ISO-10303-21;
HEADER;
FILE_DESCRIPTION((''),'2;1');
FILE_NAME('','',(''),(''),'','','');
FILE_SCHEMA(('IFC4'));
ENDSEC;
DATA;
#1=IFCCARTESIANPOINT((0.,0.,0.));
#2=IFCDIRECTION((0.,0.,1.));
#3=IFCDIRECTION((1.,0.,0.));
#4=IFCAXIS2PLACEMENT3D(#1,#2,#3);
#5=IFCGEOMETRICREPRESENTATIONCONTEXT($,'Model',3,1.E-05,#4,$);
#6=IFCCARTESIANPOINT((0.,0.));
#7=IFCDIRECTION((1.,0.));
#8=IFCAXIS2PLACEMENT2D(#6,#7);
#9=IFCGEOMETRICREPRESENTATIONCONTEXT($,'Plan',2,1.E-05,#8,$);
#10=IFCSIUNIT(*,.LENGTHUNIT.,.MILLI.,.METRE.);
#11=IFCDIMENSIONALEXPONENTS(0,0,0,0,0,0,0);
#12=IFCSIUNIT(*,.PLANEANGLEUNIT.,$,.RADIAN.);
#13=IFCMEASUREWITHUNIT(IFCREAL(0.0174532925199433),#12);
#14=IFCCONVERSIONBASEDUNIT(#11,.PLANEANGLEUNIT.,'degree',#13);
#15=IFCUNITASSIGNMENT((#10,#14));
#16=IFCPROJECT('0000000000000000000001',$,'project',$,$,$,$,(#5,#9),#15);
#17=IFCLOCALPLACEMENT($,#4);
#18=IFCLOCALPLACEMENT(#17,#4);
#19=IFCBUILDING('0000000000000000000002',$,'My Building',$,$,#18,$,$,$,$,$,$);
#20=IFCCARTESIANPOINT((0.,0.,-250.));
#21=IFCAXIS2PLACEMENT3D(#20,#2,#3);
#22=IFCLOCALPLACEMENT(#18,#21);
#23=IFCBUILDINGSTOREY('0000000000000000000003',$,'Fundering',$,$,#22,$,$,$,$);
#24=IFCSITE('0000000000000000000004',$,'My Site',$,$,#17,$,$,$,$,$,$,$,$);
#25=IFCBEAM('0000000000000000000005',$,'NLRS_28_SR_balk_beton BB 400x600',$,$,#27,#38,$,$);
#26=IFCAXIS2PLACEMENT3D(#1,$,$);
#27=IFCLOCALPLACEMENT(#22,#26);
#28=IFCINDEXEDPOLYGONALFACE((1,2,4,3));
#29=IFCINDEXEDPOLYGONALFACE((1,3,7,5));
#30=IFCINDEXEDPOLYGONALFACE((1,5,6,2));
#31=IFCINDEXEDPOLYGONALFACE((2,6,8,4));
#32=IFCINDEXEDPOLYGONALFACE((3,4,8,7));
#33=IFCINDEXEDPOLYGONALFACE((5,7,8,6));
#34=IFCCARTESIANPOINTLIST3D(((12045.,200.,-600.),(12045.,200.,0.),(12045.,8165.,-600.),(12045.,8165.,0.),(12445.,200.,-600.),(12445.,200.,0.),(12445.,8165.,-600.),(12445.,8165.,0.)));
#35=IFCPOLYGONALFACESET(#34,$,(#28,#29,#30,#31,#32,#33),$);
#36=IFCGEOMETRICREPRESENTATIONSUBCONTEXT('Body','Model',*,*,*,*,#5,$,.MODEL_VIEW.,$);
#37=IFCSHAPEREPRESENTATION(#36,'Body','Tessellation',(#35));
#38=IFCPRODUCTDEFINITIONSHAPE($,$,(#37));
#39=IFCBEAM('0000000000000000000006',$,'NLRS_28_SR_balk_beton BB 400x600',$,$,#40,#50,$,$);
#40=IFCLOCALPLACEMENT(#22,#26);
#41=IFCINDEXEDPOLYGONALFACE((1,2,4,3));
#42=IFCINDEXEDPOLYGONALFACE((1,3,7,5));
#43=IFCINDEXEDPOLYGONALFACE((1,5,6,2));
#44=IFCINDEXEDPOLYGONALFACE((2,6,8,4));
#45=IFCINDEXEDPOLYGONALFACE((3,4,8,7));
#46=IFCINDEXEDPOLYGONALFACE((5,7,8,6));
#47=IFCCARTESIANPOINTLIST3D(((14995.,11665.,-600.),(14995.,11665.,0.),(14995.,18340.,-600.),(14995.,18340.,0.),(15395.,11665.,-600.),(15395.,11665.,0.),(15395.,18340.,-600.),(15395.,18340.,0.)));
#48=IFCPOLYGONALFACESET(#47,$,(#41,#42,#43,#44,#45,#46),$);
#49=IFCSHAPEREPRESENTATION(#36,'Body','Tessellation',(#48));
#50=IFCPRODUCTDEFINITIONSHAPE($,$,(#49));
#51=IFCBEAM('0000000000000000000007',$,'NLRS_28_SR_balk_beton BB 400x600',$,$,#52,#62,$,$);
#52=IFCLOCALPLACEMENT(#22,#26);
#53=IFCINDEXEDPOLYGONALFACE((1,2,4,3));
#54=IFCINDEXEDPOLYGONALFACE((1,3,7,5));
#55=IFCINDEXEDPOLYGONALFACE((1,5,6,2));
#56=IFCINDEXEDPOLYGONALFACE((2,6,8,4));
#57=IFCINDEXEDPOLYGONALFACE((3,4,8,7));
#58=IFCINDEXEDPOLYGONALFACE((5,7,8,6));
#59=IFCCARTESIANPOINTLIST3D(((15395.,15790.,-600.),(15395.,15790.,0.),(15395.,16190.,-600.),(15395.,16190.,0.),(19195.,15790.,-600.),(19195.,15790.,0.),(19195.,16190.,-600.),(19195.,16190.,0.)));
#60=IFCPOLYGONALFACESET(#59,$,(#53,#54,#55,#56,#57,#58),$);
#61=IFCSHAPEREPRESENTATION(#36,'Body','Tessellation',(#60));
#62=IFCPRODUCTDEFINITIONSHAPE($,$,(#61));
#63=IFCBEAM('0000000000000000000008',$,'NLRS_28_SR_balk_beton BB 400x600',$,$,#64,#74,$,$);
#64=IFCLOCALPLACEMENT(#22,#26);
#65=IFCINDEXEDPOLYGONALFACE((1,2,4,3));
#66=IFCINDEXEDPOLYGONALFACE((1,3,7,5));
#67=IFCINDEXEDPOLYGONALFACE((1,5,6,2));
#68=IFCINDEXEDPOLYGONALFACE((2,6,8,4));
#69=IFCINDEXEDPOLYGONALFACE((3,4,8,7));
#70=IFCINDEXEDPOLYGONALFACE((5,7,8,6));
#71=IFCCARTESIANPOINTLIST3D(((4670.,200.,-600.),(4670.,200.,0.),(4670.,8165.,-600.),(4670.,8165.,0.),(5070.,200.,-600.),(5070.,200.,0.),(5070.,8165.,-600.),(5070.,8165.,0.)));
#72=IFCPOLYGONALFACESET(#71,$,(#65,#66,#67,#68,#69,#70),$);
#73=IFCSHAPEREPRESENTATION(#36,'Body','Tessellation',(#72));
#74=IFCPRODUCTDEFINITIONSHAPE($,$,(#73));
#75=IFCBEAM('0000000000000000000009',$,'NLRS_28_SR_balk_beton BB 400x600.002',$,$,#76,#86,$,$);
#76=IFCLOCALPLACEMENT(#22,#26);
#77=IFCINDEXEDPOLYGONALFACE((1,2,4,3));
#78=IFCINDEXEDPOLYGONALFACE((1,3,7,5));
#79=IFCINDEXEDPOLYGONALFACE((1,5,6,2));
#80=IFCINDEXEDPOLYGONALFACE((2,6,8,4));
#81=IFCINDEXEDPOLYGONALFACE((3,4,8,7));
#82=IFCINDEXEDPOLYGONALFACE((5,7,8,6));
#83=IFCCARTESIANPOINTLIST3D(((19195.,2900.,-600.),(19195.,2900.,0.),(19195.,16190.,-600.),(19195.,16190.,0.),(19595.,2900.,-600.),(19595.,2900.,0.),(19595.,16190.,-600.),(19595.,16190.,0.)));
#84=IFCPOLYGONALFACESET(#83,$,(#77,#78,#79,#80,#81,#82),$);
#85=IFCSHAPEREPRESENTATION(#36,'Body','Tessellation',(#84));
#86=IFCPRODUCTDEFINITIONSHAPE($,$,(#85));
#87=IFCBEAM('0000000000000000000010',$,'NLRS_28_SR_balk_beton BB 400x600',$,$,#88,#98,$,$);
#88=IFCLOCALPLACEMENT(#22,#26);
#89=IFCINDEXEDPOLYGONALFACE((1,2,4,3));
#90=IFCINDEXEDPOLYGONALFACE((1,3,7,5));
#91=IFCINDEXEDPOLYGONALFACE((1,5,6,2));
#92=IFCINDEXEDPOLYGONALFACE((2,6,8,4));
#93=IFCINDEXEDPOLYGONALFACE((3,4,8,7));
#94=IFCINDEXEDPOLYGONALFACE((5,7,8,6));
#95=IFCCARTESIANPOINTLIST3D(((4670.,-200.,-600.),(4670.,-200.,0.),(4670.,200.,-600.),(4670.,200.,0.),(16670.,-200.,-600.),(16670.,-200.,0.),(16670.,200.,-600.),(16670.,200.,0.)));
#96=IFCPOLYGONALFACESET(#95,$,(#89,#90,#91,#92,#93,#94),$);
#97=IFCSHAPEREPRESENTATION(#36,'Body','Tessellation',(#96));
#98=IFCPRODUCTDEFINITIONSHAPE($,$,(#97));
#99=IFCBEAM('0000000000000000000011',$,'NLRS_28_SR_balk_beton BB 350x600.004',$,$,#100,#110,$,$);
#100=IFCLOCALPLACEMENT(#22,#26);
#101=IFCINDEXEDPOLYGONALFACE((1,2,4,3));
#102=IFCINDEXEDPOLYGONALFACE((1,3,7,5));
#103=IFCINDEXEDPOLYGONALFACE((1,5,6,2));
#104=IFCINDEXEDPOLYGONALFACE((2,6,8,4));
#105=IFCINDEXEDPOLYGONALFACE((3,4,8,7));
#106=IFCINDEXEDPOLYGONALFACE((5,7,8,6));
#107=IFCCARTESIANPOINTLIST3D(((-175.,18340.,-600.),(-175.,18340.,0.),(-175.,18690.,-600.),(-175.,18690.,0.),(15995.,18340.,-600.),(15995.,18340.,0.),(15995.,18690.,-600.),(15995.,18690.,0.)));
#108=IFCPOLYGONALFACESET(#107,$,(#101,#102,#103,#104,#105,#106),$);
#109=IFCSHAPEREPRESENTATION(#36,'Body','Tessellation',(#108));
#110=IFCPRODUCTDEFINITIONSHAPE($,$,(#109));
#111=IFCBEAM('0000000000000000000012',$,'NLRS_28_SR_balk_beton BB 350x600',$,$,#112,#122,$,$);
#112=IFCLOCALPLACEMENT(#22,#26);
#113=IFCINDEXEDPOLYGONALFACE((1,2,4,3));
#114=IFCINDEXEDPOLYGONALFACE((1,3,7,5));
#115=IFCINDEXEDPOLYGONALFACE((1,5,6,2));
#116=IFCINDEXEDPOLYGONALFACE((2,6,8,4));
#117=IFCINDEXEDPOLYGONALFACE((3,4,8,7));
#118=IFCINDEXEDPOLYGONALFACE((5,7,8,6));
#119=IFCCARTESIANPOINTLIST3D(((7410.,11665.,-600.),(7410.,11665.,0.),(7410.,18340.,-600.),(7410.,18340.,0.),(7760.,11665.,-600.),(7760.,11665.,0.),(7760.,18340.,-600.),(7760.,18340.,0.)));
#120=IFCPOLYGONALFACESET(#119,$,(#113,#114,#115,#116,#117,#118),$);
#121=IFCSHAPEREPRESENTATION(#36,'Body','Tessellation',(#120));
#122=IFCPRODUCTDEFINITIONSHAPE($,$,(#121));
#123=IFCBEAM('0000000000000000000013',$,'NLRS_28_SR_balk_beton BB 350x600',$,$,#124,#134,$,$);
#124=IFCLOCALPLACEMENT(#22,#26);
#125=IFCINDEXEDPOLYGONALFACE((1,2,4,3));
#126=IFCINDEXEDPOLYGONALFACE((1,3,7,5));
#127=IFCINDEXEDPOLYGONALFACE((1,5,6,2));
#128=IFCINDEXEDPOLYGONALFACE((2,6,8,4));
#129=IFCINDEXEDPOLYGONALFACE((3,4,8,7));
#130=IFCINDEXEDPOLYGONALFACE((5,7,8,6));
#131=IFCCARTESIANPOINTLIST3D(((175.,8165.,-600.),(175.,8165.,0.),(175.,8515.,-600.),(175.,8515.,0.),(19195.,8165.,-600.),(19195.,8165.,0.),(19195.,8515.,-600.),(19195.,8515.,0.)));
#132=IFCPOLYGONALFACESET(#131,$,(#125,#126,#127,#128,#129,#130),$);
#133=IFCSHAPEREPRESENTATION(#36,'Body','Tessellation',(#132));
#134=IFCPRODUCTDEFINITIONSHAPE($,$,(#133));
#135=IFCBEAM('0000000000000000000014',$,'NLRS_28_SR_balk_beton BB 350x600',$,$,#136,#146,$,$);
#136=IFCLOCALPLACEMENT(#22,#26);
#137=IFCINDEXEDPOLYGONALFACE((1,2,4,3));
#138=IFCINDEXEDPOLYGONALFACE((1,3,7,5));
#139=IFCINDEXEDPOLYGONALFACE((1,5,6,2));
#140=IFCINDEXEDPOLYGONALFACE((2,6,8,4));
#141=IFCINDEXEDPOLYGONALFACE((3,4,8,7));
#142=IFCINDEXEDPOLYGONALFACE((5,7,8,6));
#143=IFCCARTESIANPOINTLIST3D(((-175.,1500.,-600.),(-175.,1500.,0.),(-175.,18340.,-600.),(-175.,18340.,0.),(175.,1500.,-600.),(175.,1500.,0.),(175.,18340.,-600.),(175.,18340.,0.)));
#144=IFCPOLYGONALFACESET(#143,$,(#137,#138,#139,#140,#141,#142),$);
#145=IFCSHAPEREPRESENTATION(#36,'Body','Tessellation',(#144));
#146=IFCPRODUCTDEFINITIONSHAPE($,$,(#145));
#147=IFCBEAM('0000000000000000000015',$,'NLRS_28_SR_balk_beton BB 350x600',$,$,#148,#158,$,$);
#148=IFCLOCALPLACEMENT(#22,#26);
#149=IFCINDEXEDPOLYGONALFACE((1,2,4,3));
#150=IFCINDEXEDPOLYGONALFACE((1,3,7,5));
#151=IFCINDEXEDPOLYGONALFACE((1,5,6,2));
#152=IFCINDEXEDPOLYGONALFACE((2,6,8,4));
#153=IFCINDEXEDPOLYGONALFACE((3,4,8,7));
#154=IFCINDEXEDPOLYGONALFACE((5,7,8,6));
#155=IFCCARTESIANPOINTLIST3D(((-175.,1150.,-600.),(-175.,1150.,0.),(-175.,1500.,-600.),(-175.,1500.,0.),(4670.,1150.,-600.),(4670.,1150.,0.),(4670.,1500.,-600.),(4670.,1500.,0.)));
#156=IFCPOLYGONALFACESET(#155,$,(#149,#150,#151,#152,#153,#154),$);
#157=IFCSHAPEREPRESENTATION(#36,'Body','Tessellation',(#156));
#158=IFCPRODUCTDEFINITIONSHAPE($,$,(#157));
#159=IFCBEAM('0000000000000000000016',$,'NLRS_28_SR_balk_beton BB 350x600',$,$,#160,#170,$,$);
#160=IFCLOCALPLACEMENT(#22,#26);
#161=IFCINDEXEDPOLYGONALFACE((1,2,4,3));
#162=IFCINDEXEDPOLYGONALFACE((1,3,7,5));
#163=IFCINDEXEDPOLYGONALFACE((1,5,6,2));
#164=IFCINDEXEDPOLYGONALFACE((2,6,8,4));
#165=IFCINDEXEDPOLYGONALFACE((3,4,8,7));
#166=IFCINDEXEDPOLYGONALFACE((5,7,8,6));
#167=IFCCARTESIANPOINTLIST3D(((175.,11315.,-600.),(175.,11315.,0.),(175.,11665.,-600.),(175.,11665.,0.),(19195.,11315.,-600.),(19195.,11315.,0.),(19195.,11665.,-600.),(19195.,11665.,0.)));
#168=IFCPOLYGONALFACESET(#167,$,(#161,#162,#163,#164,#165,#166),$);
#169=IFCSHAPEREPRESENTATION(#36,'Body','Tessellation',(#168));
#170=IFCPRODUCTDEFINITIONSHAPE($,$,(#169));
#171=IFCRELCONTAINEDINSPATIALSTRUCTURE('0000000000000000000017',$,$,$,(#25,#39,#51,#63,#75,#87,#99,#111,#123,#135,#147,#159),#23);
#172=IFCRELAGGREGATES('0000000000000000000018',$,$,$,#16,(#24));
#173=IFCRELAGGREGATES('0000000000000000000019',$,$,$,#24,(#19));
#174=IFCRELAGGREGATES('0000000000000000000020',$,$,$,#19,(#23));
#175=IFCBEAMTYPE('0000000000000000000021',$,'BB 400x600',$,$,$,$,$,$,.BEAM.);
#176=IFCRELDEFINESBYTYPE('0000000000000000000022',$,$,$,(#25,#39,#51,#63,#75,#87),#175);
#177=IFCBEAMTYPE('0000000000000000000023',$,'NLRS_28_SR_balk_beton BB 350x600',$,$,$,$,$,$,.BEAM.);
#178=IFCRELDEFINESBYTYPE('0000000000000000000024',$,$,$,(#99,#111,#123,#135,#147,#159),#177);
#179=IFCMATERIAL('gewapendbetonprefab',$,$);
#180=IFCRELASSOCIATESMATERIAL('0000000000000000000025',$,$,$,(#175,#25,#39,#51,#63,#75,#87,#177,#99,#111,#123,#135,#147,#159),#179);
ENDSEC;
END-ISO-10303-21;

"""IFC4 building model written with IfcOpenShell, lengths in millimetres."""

from ifc_helpers import new_model, entity, si_unit, converted_unit, frame, origin_with_axes, origin_2d_with_axis, place, context, subcontext, project, spatial, rectangle, extrude, material, material_profile, profile_set, profile_usage, type_object, element, save


model = new_model("IFC4")

# Units and contexts
model_context = context("Model", 3, precision=1e-05, world=origin_with_axes())
plan_context = context("Plan", 2, precision=1e-05, world=origin_2d_with_axis())
body_context = subcontext(model_context, "Body", "Model", "MODEL_VIEW")
ifc_project = project(units=[si_unit("LENGTHUNIT", "METRE", prefix="MILLI"), converted_unit("PLANEANGLEUNIT", "degree", entity("IfcReal", 0.0174532925199433), si_unit("PLANEANGLEUNIT", "RADIAN"), dimensions=[0, 0, 0, 0, 0, 0, 0])], contexts=[model_context, plan_context])

# Site, building, storey
site_placement = place(None, origin_with_axes())
site = spatial("IfcSite", under=ifc_project, at=site_placement, Name="My Site")
building_placement = place(site_placement, origin_with_axes())
building = spatial("IfcBuilding", under=site, at=building_placement, Name="My Building")
storey_placement = place(building_placement, frame((0.0, 0.0, -250.0), z_axis=(0.0, 0.0, 1.0), x_axis=(1.0, 0.0, 0.0)))
storey = spatial("IfcBuildingStorey", under=building, at=storey_placement, Name="Fundering")

# Beams
ifc_material = material(Name="gewapendbetonprefab")
ifc_material_profile_1 = material_profile(ifc_material, rectangle(XDim=400.0, YDim=600.0))
ifc_profile_set_1 = profile_set([ifc_material_profile_1], Name="NLRS_28_SR_balk_beton BB 400x600")
ifc_profile_usage_1 = profile_usage(ifc_profile_set_1, cardinal=8)
beam_type_1 = type_object("IfcBeamType", Name="BB 400x600", PredefinedType="BEAM", material=ifc_profile_set_1)
beam_1_placement = place(storey_placement, frame((12245.0, 200.0, 0.0), z_axis=(0.0, 1.0, 0.0), x_axis=(-1.0, 0.0, 0.0)))
element("IfcBeam", 1, at=beam_1_placement, inside=storey, type_object=beam_type_1, material=ifc_profile_usage_1, Name="NLRS_28_SR_balk_beton BB 400x600", context=body_context, shape_type="SweptSolid", body=[
    extrude(rectangle(XDim=400.0, YDim=600.0), frame((0.0, -300.0, 0.0), z_axis=(0.0, 0.0, 1.0), x_axis=(1.0, 0.0, 0.0)), (0.0, 0.0, 1.0), 7965.0),
])
ifc_profile_usage_2 = profile_usage(ifc_profile_set_1, cardinal=8)
beam_2_placement = place(storey_placement, frame((15195.0, 11665.0, 0.0), z_axis=(0.0, 1.0, 0.0), x_axis=(-1.0, 0.0, 0.0)))
element("IfcBeam", 2, at=beam_2_placement, inside=storey, type_object=beam_type_1, material=ifc_profile_usage_2, Name="NLRS_28_SR_balk_beton BB 400x600", context=body_context, shape_type="SweptSolid", body=[
    extrude(rectangle(XDim=400.0, YDim=600.0), frame((0.0, -300.0, 0.0), z_axis=(0.0, 0.0, 1.0), x_axis=(1.0, 0.0, 0.0)), (0.0, 0.0, 1.0), 6675.0),
])
ifc_profile_usage_3 = profile_usage(ifc_profile_set_1, cardinal=8)
beam_3_placement = place(storey_placement, frame((19195.0, 15990.0, 0.0), z_axis=(-1.0, 0.0, 0.0), x_axis=(0.0, -1.0, 0.0)))
element("IfcBeam", 3, at=beam_3_placement, inside=storey, type_object=beam_type_1, material=ifc_profile_usage_3, Name="NLRS_28_SR_balk_beton BB 400x600", context=body_context, shape_type="SweptSolid", body=[
    extrude(rectangle(XDim=400.0, YDim=600.0), frame((0.0, -300.0, 0.0), z_axis=(0.0, 0.0, 1.0), x_axis=(1.0, 0.0, 0.0)), (0.0, 0.0, 1.0), 3800.0),
])
ifc_profile_usage_4 = profile_usage(ifc_profile_set_1, cardinal=8)
beam_4_placement = place(storey_placement, frame((4870.0, 200.0, 0.0), z_axis=(0.0, 1.0, 0.0), x_axis=(-1.0, 0.0, 0.0)))
element("IfcBeam", 4, at=beam_4_placement, inside=storey, type_object=beam_type_1, material=ifc_profile_usage_4, Name="NLRS_28_SR_balk_beton BB 400x600", context=body_context, shape_type="SweptSolid", body=[
    extrude(rectangle(XDim=400.0, YDim=600.0), frame((0.0, -300.0, 0.0), z_axis=(0.0, 0.0, 1.0), x_axis=(1.0, 0.0, 0.0)), (0.0, 0.0, 1.0), 7965.0),
])
ifc_profile_usage_5 = profile_usage(ifc_profile_set_1, cardinal=8)
beam_5_placement = place(storey_placement, frame((19395.0, 2900.0, 0.0), z_axis=(0.0, 1.0, 0.0), x_axis=(-1.0, 0.0, 0.0)))
element("IfcBeam", 5, at=beam_5_placement, inside=storey, type_object=beam_type_1, material=ifc_profile_usage_5, Name="NLRS_28_SR_balk_beton BB 400x600.002", context=body_context, shape_type="SweptSolid", body=[
    extrude(rectangle(XDim=400.0, YDim=600.0), frame((0.0, -300.0, 0.0), z_axis=(0.0, 0.0, 1.0), x_axis=(1.0, 0.0, 0.0)), (0.0, 0.0, 1.0), 13290.0),
])
ifc_profile_usage_6 = profile_usage(ifc_profile_set_1, cardinal=8)
beam_6_placement = place(storey_placement, frame((4670.0, 0.0, 0.0), z_axis=(1.0, 0.0, 0.0), x_axis=(0.0, 1.0, 0.0)))
element("IfcBeam", 6, at=beam_6_placement, inside=storey, type_object=beam_type_1, material=ifc_profile_usage_6, Name="NLRS_28_SR_balk_beton BB 400x600", context=body_context, shape_type="SweptSolid", body=[
    extrude(rectangle(XDim=400.0, YDim=600.0), frame((0.0, -300.0, 0.0), z_axis=(0.0, 0.0, 1.0), x_axis=(1.0, 0.0, 0.0)), (0.0, 0.0, 1.0), 12000.0),
])
ifc_material_profile_2 = material_profile(ifc_material, rectangle(XDim=350.0, YDim=600.0))
ifc_profile_set_2 = profile_set([ifc_material_profile_2], Name="NLRS_28_SR_balk_beton BB 350x600")
ifc_profile_usage_7 = profile_usage(ifc_profile_set_2, cardinal=8)
beam_type_2 = type_object("IfcBeamType", Name="NLRS_28_SR_balk_beton BB 350x600", PredefinedType="BEAM", material=ifc_profile_set_2)
beam_7_placement = place(storey_placement, frame((-175.0, 18515.0, 0.0), z_axis=(1.0, 0.0, 0.0), x_axis=(0.0, 1.0, 0.0)))
element("IfcBeam", 7, at=beam_7_placement, inside=storey, type_object=beam_type_2, material=ifc_profile_usage_7, Name="NLRS_28_SR_balk_beton BB 350x600.004", context=body_context, shape_type="SweptSolid", body=[
    extrude(rectangle(XDim=350.0, YDim=600.0), frame((0.0, -300.0, 0.0)), (0.0, 0.0, 1.0), 16170.0),
])
ifc_profile_usage_8 = profile_usage(ifc_profile_set_2, cardinal=8)
beam_8_placement = place(storey_placement, frame((7585.0, 11665.0, 0.0), z_axis=(0.0, 1.0, 0.0), x_axis=(-1.0, 0.0, 0.0)))
element("IfcBeam", 8, at=beam_8_placement, inside=storey, type_object=beam_type_2, material=ifc_profile_usage_8, Name="NLRS_28_SR_balk_beton BB 350x600", context=body_context, shape_type="SweptSolid", body=[
    extrude(rectangle(XDim=350.0, YDim=600.0), frame((0.0, -300.0, 0.0), z_axis=(0.0, 0.0, 1.0), x_axis=(1.0, 0.0, 0.0)), (0.0, 0.0, 1.0), 6675.0),
])
ifc_profile_usage_9 = profile_usage(ifc_profile_set_2, cardinal=8)
beam_9_placement = place(storey_placement, frame((19195.0, 8340.0, 0.0), z_axis=(-1.0, 0.0, 0.0), x_axis=(0.0, -1.0, 0.0)))
element("IfcBeam", 9, at=beam_9_placement, inside=storey, type_object=beam_type_2, material=ifc_profile_usage_9, Name="NLRS_28_SR_balk_beton BB 350x600", context=body_context, shape_type="SweptSolid", body=[
    extrude(rectangle(XDim=350.0, YDim=600.0), frame((0.0, -300.0, 0.0), z_axis=(0.0, 0.0, 1.0), x_axis=(1.0, 0.0, 0.0)), (0.0, 0.0, 1.0), 19020.0),
])
ifc_profile_usage_10 = profile_usage(ifc_profile_set_2, cardinal=8)
beam_10_placement = place(storey_placement, frame((0.0, 1500.0, 0.0), z_axis=(0.0, 1.0, 0.0), x_axis=(-1.0, 0.0, 0.0)))
element("IfcBeam", 10, at=beam_10_placement, inside=storey, type_object=beam_type_2, material=ifc_profile_usage_10, Name="NLRS_28_SR_balk_beton BB 350x600", context=body_context, shape_type="SweptSolid", body=[
    extrude(rectangle(XDim=350.0, YDim=600.0), frame((0.0, -300.0, 0.0), z_axis=(0.0, 0.0, 1.0), x_axis=(1.0, 0.0, 0.0)), (0.0, 0.0, 1.0), 16840.0),
])
ifc_profile_usage_11 = profile_usage(ifc_profile_set_2, cardinal=8)
beam_11_placement = place(storey_placement, frame((4670.0, 1325.0, 0.0), z_axis=(-1.0, 0.0, 0.0), x_axis=(0.0, -1.0, 0.0)))
element("IfcBeam", 11, at=beam_11_placement, inside=storey, type_object=beam_type_2, material=ifc_profile_usage_11, Name="NLRS_28_SR_balk_beton BB 350x600", context=body_context, shape_type="SweptSolid", body=[
    extrude(rectangle(XDim=350.0, YDim=600.0), frame((0.0, -300.0, 0.0), z_axis=(0.0, 0.0, 1.0), x_axis=(1.0, 0.0, 0.0)), (0.0, 0.0, 1.0), 4845.0),
])
ifc_profile_usage_12 = profile_usage(ifc_profile_set_2, cardinal=8)
beam_12_placement = place(storey_placement, frame((19195.0, 11490.0, 0.0), z_axis=(-1.0, 0.0, 0.0), x_axis=(0.0, -1.0, 0.0)))
element("IfcBeam", 12, at=beam_12_placement, inside=storey, type_object=beam_type_2, material=ifc_profile_usage_12, Name="NLRS_28_SR_balk_beton BB 350x600", context=body_context, shape_type="SweptSolid", body=[
    extrude(rectangle(XDim=350.0, YDim=600.0), frame((0.0, -300.0, 0.0), z_axis=(0.0, 0.0, 1.0), x_axis=(1.0, 0.0, 0.0)), (0.0, 0.0, 1.0), 19020.0),
])

save(model, "model.ifc")
